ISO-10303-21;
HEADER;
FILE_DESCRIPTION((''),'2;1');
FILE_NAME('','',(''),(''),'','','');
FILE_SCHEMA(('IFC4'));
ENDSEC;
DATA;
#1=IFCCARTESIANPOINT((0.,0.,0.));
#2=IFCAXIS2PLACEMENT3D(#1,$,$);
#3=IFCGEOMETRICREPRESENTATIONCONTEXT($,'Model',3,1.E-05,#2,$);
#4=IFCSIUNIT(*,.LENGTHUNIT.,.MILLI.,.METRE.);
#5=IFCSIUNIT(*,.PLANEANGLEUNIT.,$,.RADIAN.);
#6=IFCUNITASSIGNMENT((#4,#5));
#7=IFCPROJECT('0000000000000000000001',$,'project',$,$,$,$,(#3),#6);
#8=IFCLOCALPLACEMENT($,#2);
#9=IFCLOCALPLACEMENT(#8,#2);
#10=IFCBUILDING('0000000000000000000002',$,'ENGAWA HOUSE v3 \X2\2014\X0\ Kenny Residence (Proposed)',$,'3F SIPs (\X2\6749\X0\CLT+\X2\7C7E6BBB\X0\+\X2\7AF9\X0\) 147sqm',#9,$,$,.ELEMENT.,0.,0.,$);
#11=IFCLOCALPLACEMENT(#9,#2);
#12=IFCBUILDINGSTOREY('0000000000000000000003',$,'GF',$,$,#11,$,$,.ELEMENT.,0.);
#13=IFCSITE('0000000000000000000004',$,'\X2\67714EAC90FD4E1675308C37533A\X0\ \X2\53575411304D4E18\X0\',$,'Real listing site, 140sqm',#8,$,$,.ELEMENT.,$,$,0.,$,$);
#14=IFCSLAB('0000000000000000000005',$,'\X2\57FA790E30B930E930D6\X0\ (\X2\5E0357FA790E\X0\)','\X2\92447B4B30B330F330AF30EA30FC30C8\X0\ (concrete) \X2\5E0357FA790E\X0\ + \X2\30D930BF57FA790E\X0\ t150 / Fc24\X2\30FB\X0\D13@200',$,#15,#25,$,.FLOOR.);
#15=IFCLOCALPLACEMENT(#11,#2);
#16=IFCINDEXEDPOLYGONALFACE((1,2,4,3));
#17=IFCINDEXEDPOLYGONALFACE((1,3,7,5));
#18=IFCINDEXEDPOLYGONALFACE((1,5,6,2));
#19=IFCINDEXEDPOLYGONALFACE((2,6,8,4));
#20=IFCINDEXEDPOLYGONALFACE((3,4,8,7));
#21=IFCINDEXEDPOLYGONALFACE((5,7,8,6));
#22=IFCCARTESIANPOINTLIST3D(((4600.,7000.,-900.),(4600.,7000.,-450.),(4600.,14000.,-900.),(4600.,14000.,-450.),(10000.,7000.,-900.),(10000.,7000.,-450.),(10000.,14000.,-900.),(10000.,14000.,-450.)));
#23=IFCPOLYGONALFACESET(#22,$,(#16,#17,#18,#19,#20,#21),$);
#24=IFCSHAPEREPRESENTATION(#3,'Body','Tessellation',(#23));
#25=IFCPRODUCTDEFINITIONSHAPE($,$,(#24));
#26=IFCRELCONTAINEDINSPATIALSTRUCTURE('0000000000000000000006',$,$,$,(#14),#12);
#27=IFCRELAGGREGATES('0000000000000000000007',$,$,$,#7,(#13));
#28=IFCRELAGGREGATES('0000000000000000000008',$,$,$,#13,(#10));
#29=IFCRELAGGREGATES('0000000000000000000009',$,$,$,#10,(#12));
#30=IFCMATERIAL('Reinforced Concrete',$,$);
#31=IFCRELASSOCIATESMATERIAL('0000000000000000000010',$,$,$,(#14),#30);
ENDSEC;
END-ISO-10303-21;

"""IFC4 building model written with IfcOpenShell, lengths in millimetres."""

from ifc_helpers import new_model, si_unit, frame, frame_2d, origin, place, context, project, spatial, rectangle, extrude, material, element, save


model = new_model("IFC4")

# Units and contexts
model_context = context("Model", 3, precision=1e-05, world=origin())
ifc_project = project(units=[si_unit("LENGTHUNIT", "METRE", prefix="MILLI"), si_unit("PLANEANGLEUNIT", "RADIAN")], contexts=[model_context])

# Site, building, storey
site_placement = place(None, origin())
site = spatial("IfcSite", under=ifc_project, at=site_placement, Name="東京都世田谷区 南向き丘", ObjectType="Real listing site, 140sqm", CompositionType="ELEMENT", RefElevation=0.0)
building_placement = place(site_placement, origin())
building = spatial("IfcBuilding", under=site, at=building_placement, Name="ENGAWA HOUSE v3 — Kenny Residence (Proposed)", ObjectType="3F SIPs (杉CLT+籾殻+竹) 147sqm", CompositionType="ELEMENT", ElevationOfRefHeight=0.0, ElevationOfTerrain=0.0)
storey_placement = place(building_placement, origin())
storey = spatial("IfcBuildingStorey", under=building, at=storey_placement, Name="GF", CompositionType="ELEMENT", Elevation=0.0)

# Slab
ifc_material_1 = material(Name="Reinforced Concrete")
slab_1_placement = place(storey_placement, frame((2300.0, 3500.0, -450.0)))
element("IfcSlab", 1, at=slab_1_placement, inside=storey, material=ifc_material_1, Name="基礎スラブ (布基礎)", Description="鉄筋コンクリート (concrete) 布基礎 + ベタ基礎 t150 / Fc24・D13@200", PredefinedType="FLOOR", context=model_context, shape_type="SweptSolid", body=[
    extrude(rectangle(XDim=5400.0, YDim=7000.0, at=frame_2d((2700.0, 3500.0))), frame((2300.0, 3500.0, -450.0)), (0.0, 0.0, 1.0), 450.0),
])

save(model, "model.ifc")
